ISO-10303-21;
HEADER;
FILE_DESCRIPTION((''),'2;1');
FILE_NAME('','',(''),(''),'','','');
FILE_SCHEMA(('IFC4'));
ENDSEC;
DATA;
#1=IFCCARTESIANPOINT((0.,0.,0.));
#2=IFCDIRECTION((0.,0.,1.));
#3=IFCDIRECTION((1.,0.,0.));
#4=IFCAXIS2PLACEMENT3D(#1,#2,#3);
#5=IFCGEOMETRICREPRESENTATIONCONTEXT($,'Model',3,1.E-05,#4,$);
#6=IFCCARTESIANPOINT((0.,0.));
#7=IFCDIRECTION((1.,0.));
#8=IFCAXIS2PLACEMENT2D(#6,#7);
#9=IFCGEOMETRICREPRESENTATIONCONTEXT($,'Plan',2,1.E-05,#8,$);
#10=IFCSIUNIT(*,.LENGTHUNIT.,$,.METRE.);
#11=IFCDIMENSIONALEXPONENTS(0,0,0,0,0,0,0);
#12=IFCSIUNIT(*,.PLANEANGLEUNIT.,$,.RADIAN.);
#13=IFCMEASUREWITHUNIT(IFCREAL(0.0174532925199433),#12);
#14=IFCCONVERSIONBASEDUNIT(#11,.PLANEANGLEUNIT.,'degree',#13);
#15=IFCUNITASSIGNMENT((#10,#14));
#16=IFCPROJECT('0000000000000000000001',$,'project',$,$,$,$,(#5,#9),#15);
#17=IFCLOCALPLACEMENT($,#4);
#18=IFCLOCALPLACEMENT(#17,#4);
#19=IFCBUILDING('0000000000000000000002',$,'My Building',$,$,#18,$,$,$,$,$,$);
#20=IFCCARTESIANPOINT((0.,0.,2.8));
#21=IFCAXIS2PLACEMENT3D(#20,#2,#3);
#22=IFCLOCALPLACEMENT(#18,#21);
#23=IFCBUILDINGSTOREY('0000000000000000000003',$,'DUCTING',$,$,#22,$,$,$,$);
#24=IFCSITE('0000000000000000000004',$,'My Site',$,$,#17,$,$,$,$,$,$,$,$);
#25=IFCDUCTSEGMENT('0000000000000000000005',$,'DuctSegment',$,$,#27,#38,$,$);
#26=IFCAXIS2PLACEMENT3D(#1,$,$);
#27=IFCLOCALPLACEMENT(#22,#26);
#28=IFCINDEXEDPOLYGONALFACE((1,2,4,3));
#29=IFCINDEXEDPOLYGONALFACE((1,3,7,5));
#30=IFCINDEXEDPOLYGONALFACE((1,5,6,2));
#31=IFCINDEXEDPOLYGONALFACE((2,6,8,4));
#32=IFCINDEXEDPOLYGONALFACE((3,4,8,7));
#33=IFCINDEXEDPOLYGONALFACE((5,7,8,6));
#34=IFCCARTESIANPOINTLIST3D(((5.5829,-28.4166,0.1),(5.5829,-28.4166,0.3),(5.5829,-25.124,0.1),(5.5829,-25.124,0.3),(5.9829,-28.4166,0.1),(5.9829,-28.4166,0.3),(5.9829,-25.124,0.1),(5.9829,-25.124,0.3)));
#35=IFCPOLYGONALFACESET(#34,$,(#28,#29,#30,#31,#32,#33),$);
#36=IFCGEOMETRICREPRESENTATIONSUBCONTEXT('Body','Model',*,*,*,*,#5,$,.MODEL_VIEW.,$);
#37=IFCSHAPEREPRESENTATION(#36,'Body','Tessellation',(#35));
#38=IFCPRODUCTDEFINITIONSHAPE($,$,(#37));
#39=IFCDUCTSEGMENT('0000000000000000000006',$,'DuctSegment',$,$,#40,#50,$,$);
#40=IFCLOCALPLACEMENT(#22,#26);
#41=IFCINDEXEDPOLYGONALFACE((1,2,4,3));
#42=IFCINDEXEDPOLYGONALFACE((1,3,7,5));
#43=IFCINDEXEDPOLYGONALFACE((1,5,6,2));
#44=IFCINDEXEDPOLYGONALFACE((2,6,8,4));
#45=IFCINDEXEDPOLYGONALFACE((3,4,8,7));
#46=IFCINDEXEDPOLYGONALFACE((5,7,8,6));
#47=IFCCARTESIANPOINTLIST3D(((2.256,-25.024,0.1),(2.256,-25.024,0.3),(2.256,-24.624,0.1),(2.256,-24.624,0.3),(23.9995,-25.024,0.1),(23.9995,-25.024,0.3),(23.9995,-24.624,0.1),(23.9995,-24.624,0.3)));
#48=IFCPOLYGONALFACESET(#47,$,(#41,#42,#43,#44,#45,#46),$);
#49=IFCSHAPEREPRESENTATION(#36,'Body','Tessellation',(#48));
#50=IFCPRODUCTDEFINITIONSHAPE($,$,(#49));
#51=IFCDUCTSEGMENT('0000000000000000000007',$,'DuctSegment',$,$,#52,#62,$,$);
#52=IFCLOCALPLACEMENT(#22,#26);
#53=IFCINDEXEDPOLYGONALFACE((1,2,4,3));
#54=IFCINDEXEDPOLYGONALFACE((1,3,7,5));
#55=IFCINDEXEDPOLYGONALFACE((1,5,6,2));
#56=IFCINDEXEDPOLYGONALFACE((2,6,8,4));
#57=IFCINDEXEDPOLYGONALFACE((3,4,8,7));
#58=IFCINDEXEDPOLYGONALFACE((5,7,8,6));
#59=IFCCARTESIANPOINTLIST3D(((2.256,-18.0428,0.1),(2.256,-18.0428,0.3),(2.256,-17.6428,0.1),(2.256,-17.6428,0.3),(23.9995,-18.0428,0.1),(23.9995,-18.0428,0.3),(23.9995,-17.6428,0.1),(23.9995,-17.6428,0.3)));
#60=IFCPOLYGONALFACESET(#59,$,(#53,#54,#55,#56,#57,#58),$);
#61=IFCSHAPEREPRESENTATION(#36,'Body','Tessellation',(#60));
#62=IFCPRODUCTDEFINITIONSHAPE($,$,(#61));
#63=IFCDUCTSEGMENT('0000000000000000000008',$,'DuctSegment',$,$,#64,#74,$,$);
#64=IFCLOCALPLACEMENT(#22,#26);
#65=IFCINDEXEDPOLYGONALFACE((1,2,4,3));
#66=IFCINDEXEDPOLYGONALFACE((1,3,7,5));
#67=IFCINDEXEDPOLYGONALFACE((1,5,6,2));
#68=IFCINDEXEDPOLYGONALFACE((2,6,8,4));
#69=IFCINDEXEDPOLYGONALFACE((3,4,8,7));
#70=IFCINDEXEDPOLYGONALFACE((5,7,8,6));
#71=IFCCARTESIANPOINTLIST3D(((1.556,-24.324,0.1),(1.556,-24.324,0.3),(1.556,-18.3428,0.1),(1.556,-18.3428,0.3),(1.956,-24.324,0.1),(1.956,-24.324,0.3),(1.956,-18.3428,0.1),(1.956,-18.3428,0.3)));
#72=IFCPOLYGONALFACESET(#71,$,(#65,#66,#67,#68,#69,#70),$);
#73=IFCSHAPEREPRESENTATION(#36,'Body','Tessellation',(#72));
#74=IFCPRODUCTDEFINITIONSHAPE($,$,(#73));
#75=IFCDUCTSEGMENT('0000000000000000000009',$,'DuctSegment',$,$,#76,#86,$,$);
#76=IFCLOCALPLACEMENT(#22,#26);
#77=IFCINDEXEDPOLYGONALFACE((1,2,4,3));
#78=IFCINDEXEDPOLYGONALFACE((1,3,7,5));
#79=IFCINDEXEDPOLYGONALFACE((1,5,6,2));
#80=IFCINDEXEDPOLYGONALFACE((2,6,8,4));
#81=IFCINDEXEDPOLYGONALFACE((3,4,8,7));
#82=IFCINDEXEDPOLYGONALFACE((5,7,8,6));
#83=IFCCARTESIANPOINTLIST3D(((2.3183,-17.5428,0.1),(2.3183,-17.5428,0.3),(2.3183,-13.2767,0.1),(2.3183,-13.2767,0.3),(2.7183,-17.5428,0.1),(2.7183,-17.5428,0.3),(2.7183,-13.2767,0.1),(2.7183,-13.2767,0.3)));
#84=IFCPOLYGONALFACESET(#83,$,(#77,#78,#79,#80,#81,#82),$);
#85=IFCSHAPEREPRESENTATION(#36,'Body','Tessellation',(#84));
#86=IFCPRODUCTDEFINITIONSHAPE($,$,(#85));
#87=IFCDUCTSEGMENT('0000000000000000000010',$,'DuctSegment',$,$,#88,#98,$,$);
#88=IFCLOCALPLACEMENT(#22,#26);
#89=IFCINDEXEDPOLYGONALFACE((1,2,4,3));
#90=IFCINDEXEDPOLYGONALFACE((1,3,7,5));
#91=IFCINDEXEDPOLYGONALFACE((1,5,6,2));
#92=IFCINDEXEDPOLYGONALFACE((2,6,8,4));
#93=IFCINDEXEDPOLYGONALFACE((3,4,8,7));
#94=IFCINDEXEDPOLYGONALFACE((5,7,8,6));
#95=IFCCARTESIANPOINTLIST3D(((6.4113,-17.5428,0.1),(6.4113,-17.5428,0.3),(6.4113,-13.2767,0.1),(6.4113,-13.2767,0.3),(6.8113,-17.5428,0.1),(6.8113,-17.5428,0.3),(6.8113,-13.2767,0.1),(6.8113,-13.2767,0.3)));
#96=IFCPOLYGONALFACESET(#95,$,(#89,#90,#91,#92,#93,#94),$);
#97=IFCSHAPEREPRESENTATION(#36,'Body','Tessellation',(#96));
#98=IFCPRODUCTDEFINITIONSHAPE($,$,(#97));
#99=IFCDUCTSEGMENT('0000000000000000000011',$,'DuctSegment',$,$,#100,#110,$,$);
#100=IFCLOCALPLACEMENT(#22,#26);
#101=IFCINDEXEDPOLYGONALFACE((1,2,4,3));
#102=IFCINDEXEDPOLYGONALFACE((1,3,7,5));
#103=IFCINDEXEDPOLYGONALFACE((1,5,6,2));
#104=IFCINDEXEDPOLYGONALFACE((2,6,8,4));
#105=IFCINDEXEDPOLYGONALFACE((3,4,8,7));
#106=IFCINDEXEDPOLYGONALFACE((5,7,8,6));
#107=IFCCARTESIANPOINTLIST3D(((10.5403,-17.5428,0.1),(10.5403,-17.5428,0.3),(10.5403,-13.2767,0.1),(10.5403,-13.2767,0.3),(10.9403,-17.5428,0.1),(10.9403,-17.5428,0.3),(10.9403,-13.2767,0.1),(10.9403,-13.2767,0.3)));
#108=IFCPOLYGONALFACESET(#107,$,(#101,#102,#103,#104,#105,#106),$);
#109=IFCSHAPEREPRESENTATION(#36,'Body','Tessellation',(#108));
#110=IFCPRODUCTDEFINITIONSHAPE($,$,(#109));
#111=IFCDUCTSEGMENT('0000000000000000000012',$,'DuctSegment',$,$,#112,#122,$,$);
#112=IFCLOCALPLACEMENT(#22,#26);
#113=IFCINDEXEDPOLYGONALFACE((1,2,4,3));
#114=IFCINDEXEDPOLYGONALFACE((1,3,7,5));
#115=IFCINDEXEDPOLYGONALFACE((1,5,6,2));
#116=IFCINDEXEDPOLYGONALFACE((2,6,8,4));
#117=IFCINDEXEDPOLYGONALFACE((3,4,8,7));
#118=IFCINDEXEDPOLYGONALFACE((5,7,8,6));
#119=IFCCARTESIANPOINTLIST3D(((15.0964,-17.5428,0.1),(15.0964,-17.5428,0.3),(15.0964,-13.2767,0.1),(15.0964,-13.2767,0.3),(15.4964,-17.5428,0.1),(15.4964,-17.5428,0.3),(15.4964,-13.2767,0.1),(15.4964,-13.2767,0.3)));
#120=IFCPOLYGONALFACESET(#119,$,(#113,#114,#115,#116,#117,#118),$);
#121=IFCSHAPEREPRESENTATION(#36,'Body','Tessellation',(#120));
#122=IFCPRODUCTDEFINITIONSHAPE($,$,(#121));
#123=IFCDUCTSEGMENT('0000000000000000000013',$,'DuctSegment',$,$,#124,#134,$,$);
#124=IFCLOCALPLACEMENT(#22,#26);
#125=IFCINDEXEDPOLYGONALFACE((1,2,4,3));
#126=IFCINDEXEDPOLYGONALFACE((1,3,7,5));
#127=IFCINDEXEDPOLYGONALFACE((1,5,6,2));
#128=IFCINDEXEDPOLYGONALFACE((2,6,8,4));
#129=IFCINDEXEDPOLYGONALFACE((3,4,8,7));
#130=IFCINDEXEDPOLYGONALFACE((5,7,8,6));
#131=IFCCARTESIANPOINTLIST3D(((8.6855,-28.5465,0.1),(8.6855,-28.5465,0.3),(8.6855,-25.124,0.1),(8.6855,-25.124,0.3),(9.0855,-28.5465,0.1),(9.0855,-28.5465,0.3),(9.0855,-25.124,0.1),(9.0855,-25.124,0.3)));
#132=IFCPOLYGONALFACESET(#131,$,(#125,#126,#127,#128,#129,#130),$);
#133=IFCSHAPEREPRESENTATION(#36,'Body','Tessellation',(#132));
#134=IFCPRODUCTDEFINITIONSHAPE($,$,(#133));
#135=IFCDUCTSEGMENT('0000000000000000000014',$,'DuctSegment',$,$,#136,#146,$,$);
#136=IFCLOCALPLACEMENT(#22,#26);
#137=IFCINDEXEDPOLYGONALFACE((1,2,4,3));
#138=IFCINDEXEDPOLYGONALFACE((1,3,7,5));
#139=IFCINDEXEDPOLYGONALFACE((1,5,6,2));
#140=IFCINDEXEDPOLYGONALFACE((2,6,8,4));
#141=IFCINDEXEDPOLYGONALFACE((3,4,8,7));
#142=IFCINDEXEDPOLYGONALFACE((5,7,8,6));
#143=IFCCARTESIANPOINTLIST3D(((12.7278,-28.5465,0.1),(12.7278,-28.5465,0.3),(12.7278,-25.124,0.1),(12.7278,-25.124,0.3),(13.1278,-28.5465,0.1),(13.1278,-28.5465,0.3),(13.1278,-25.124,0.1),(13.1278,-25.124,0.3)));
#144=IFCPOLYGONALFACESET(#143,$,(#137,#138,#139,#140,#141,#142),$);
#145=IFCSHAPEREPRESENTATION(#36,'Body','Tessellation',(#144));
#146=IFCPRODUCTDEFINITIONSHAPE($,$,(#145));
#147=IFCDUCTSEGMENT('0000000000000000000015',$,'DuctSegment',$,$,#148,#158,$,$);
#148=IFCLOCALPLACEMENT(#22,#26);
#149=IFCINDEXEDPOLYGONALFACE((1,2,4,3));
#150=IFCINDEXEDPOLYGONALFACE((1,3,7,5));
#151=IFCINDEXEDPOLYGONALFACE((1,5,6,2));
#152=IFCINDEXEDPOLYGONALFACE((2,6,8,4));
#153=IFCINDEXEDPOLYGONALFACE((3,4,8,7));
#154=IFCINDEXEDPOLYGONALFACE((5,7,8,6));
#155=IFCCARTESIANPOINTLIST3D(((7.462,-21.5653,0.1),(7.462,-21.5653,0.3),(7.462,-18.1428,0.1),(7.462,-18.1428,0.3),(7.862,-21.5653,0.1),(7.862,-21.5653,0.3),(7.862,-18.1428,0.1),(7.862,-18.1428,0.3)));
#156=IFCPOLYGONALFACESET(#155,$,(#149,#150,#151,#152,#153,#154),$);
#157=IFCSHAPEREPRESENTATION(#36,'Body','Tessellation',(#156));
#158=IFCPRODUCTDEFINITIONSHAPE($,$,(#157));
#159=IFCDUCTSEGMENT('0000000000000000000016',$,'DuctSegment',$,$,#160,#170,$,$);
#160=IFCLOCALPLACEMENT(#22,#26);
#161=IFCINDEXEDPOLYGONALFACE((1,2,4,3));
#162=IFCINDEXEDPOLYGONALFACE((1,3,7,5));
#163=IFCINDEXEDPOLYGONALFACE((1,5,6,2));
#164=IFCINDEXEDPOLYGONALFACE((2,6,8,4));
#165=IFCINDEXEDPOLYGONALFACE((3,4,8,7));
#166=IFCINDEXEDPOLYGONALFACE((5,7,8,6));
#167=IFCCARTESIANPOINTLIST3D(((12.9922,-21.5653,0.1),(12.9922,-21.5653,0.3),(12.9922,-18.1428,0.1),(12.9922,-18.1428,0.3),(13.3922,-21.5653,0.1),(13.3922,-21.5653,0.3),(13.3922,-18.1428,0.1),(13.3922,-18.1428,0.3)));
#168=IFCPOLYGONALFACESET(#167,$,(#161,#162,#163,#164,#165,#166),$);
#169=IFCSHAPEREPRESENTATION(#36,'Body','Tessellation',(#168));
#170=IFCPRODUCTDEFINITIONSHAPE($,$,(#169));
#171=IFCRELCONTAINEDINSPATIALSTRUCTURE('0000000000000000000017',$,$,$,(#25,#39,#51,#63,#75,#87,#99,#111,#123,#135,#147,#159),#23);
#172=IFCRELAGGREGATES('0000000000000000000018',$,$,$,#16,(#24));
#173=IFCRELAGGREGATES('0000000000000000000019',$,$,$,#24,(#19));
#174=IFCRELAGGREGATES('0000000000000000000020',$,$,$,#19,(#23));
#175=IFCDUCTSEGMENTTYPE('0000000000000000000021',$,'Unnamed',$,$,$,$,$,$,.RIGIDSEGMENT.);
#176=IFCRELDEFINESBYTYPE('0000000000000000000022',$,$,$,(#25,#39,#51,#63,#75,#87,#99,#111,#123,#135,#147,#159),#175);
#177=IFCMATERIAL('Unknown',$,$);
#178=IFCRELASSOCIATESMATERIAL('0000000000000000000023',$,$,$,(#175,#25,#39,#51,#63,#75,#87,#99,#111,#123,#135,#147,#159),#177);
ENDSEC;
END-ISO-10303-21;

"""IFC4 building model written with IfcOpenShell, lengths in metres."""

from ifc_helpers import new_model, entity, si_unit, converted_unit, frame, origin_with_axes, origin_2d_with_axis, place, context, subcontext, project, spatial, rectangle, extrude, material, material_profile, profile_set, profile_usage, type_object, element, save


model = new_model("IFC4")

# Units and contexts
model_context = context("Model", 3, precision=1e-05, world=origin_with_axes())
plan_context = context("Plan", 2, precision=1e-05, world=origin_2d_with_axis())
body_context = subcontext(model_context, "Body", "Model", "MODEL_VIEW")
ifc_project = project(units=[si_unit("LENGTHUNIT", "METRE"), converted_unit("PLANEANGLEUNIT", "degree", entity("IfcReal", 0.0174532925199433), si_unit("PLANEANGLEUNIT", "RADIAN"), dimensions=[0, 0, 0, 0, 0, 0, 0])], contexts=[model_context, plan_context])

# Site, building, storey
site_placement = place(None, origin_with_axes())
site = spatial("IfcSite", under=ifc_project, at=site_placement, Name="My Site")
building_placement = place(site_placement, origin_with_axes())
building = spatial("IfcBuilding", under=site, at=building_placement, Name="My Building")
storey_placement = place(building_placement, frame((0.0, 0.0, 2.8), z_axis=(0.0, 0.0, 1.0), x_axis=(1.0, 0.0, 0.0)))
storey = spatial("IfcBuildingStorey", under=building, at=storey_placement, Name="DUCTING")

# Duct segments
ifc_material = material(Name="Unknown")
ifc_material_profile_1 = material_profile(ifc_material, rectangle(XDim=0.4, YDim=0.2))
ifc_profile_set_1 = profile_set([ifc_material_profile_1])
ifc_profile_usage_1 = profile_usage(ifc_profile_set_1, cardinal=5)
duct_segment_type = type_object("IfcDuctSegmentType", Name="Unnamed", PredefinedType="RIGIDSEGMENT", material=ifc_profile_set_1)
duct_segment_1_placement = place(storey_placement, frame((5.7829, -28.4166, 0.2), z_axis=(0.0, 1.0, 0.0), x_axis=(-1.0, 0.0, 0.0)))
element("IfcDuctSegment", 1, at=duct_segment_1_placement, inside=storey, type_object=duct_segment_type, material=ifc_profile_usage_1, Name="DuctSegment", context=body_context, shape_type="SweptSolid", body=[
    extrude(rectangle(XDim=0.4, YDim=0.2), origin_with_axes(), (0.0, 0.0, 1.0), 3.2926),
])
ifc_profile_usage_2 = profile_usage(ifc_profile_set_1, cardinal=5)
duct_segment_2_placement = place(storey_placement, frame((2.256, -24.824, 0.2), z_axis=(1.0, 0.0, 0.0), x_axis=(0.0, 1.0, 0.0)))
element("IfcDuctSegment", 2, at=duct_segment_2_placement, inside=storey, type_object=duct_segment_type, material=ifc_profile_usage_2, Name="DuctSegment", context=body_context, shape_type="SweptSolid", body=[
    extrude(rectangle(XDim=0.4, YDim=0.2), origin_with_axes(), (0.0, 0.0, 1.0), 21.7435),
])
ifc_profile_usage_3 = profile_usage(ifc_profile_set_1, cardinal=5)
duct_segment_3_placement = place(storey_placement, frame((2.256, -17.8428, 0.2), z_axis=(1.0, 0.0, 0.0), x_axis=(0.0, 1.0, 0.0)))
element("IfcDuctSegment", 3, at=duct_segment_3_placement, inside=storey, type_object=duct_segment_type, material=ifc_profile_usage_3, Name="DuctSegment", context=body_context, shape_type="SweptSolid", body=[
    extrude(rectangle(XDim=0.4, YDim=0.2), origin_with_axes(), (0.0, 0.0, 1.0), 21.7435),
])
ifc_profile_usage_4 = profile_usage(ifc_profile_set_1, cardinal=5)
duct_segment_4_placement = place(storey_placement, frame((1.756, -18.3428, 0.2), z_axis=(0.0, -1.0, 0.0), x_axis=(1.0, 0.0, 0.0)))
element("IfcDuctSegment", 4, at=duct_segment_4_placement, inside=storey, type_object=duct_segment_type, material=ifc_profile_usage_4, Name="DuctSegment", context=body_context, shape_type="SweptSolid", body=[
    extrude(rectangle(XDim=0.4, YDim=0.2), origin_with_axes(), (0.0, 0.0, 1.0), 5.9812),
])
ifc_profile_usage_5 = profile_usage(ifc_profile_set_1, cardinal=5)
duct_segment_5_placement = place(storey_placement, frame((2.5183, -17.5428, 0.2), z_axis=(0.0, 1.0, 0.0), x_axis=(-1.0, 0.0, 0.0)))
element("IfcDuctSegment", 5, at=duct_segment_5_placement, inside=storey, type_object=duct_segment_type, material=ifc_profile_usage_5, Name="DuctSegment", context=body_context, shape_type="SweptSolid", body=[
    extrude(rectangle(XDim=0.4, YDim=0.2), origin_with_axes(), (0.0, 0.0, 1.0), 4.2661),
])
ifc_profile_usage_6 = profile_usage(ifc_profile_set_1, cardinal=5)
duct_segment_6_placement = place(storey_placement, frame((6.6113, -17.5428, 0.2), z_axis=(0.0, 1.0, 0.0), x_axis=(-1.0, 0.0, 0.0)))
element("IfcDuctSegment", 6, at=duct_segment_6_placement, inside=storey, type_object=duct_segment_type, material=ifc_profile_usage_6, Name="DuctSegment", context=body_context, shape_type="SweptSolid", body=[
    extrude(rectangle(XDim=0.4, YDim=0.2), origin_with_axes(), (0.0, 0.0, 1.0), 4.2661),
])
ifc_profile_usage_7 = profile_usage(ifc_profile_set_1, cardinal=5)
duct_segment_7_placement = place(storey_placement, frame((10.7403, -17.5428, 0.2), z_axis=(0.0, 1.0, 0.0), x_axis=(-1.0, 0.0, 0.0)))
element("IfcDuctSegment", 7, at=duct_segment_7_placement, inside=storey, type_object=duct_segment_type, material=ifc_profile_usage_7, Name="DuctSegment", context=body_context, shape_type="SweptSolid", body=[
    extrude(rectangle(XDim=0.4, YDim=0.2), origin_with_axes(), (0.0, 0.0, 1.0), 4.2661),
])
ifc_profile_usage_8 = profile_usage(ifc_profile_set_1, cardinal=5)
duct_segment_8_placement = place(storey_placement, frame((15.2964, -17.5428, 0.2), z_axis=(0.0, 1.0, 0.0), x_axis=(-1.0, 0.0, 0.0)))
element("IfcDuctSegment", 8, at=duct_segment_8_placement, inside=storey, type_object=duct_segment_type, material=ifc_profile_usage_8, Name="DuctSegment", context=body_context, shape_type="SweptSolid", body=[
    extrude(rectangle(XDim=0.4, YDim=0.2), origin_with_axes(), (0.0, 0.0, 1.0), 4.2661),
])
ifc_profile_usage_9 = profile_usage(ifc_profile_set_1, cardinal=5)
duct_segment_9_placement = place(storey_placement, frame((8.8855, -25.124, 0.2), z_axis=(0.0, -1.0, 0.0), x_axis=(1.0, 0.0, 0.0)))
element("IfcDuctSegment", 9, at=duct_segment_9_placement, inside=storey, type_object=duct_segment_type, material=ifc_profile_usage_9, Name="DuctSegment", context=body_context, shape_type="SweptSolid", body=[
    extrude(rectangle(XDim=0.4, YDim=0.2), origin_with_axes(), (0.0, 0.0, 1.0), 3.4225),
])
ifc_profile_usage_10 = profile_usage(ifc_profile_set_1, cardinal=5)
duct_segment_10_placement = place(storey_placement, frame((12.9278, -25.124, 0.2), z_axis=(0.0, -1.0, 0.0), x_axis=(1.0, 0.0, 0.0)))
element("IfcDuctSegment", 10, at=duct_segment_10_placement, inside=storey, type_object=duct_segment_type, material=ifc_profile_usage_10, Name="DuctSegment", context=body_context, shape_type="SweptSolid", body=[
    extrude(rectangle(XDim=0.4, YDim=0.2), origin_with_axes(), (0.0, 0.0, 1.0), 3.4225),
])
ifc_profile_usage_11 = profile_usage(ifc_profile_set_1, cardinal=5)
duct_segment_11_placement = place(storey_placement, frame((7.662, -18.1428, 0.2), z_axis=(0.0, -1.0, 0.0), x_axis=(1.0, 0.0, 0.0)))
element("IfcDuctSegment", 11, at=duct_segment_11_placement, inside=storey, type_object=duct_segment_type, material=ifc_profile_usage_11, Name="DuctSegment", context=body_context, shape_type="SweptSolid", body=[
    extrude(rectangle(XDim=0.4, YDim=0.2), origin_with_axes(), (0.0, 0.0, 1.0), 3.4225),
])
ifc_profile_usage_12 = profile_usage(ifc_profile_set_1, cardinal=5)
duct_segment_12_placement = place(storey_placement, frame((13.1922, -18.1428, 0.2), z_axis=(0.0, -1.0, 0.0), x_axis=(1.0, 0.0, 0.0)))
element("IfcDuctSegment", 12, at=duct_segment_12_placement, inside=storey, type_object=duct_segment_type, material=ifc_profile_usage_12, Name="DuctSegment", context=body_context, shape_type="SweptSolid", body=[
    extrude(rectangle(XDim=0.4, YDim=0.2), origin_with_axes(), (0.0, 0.0, 1.0), 3.4225),
])

save(model, "model.ifc")
